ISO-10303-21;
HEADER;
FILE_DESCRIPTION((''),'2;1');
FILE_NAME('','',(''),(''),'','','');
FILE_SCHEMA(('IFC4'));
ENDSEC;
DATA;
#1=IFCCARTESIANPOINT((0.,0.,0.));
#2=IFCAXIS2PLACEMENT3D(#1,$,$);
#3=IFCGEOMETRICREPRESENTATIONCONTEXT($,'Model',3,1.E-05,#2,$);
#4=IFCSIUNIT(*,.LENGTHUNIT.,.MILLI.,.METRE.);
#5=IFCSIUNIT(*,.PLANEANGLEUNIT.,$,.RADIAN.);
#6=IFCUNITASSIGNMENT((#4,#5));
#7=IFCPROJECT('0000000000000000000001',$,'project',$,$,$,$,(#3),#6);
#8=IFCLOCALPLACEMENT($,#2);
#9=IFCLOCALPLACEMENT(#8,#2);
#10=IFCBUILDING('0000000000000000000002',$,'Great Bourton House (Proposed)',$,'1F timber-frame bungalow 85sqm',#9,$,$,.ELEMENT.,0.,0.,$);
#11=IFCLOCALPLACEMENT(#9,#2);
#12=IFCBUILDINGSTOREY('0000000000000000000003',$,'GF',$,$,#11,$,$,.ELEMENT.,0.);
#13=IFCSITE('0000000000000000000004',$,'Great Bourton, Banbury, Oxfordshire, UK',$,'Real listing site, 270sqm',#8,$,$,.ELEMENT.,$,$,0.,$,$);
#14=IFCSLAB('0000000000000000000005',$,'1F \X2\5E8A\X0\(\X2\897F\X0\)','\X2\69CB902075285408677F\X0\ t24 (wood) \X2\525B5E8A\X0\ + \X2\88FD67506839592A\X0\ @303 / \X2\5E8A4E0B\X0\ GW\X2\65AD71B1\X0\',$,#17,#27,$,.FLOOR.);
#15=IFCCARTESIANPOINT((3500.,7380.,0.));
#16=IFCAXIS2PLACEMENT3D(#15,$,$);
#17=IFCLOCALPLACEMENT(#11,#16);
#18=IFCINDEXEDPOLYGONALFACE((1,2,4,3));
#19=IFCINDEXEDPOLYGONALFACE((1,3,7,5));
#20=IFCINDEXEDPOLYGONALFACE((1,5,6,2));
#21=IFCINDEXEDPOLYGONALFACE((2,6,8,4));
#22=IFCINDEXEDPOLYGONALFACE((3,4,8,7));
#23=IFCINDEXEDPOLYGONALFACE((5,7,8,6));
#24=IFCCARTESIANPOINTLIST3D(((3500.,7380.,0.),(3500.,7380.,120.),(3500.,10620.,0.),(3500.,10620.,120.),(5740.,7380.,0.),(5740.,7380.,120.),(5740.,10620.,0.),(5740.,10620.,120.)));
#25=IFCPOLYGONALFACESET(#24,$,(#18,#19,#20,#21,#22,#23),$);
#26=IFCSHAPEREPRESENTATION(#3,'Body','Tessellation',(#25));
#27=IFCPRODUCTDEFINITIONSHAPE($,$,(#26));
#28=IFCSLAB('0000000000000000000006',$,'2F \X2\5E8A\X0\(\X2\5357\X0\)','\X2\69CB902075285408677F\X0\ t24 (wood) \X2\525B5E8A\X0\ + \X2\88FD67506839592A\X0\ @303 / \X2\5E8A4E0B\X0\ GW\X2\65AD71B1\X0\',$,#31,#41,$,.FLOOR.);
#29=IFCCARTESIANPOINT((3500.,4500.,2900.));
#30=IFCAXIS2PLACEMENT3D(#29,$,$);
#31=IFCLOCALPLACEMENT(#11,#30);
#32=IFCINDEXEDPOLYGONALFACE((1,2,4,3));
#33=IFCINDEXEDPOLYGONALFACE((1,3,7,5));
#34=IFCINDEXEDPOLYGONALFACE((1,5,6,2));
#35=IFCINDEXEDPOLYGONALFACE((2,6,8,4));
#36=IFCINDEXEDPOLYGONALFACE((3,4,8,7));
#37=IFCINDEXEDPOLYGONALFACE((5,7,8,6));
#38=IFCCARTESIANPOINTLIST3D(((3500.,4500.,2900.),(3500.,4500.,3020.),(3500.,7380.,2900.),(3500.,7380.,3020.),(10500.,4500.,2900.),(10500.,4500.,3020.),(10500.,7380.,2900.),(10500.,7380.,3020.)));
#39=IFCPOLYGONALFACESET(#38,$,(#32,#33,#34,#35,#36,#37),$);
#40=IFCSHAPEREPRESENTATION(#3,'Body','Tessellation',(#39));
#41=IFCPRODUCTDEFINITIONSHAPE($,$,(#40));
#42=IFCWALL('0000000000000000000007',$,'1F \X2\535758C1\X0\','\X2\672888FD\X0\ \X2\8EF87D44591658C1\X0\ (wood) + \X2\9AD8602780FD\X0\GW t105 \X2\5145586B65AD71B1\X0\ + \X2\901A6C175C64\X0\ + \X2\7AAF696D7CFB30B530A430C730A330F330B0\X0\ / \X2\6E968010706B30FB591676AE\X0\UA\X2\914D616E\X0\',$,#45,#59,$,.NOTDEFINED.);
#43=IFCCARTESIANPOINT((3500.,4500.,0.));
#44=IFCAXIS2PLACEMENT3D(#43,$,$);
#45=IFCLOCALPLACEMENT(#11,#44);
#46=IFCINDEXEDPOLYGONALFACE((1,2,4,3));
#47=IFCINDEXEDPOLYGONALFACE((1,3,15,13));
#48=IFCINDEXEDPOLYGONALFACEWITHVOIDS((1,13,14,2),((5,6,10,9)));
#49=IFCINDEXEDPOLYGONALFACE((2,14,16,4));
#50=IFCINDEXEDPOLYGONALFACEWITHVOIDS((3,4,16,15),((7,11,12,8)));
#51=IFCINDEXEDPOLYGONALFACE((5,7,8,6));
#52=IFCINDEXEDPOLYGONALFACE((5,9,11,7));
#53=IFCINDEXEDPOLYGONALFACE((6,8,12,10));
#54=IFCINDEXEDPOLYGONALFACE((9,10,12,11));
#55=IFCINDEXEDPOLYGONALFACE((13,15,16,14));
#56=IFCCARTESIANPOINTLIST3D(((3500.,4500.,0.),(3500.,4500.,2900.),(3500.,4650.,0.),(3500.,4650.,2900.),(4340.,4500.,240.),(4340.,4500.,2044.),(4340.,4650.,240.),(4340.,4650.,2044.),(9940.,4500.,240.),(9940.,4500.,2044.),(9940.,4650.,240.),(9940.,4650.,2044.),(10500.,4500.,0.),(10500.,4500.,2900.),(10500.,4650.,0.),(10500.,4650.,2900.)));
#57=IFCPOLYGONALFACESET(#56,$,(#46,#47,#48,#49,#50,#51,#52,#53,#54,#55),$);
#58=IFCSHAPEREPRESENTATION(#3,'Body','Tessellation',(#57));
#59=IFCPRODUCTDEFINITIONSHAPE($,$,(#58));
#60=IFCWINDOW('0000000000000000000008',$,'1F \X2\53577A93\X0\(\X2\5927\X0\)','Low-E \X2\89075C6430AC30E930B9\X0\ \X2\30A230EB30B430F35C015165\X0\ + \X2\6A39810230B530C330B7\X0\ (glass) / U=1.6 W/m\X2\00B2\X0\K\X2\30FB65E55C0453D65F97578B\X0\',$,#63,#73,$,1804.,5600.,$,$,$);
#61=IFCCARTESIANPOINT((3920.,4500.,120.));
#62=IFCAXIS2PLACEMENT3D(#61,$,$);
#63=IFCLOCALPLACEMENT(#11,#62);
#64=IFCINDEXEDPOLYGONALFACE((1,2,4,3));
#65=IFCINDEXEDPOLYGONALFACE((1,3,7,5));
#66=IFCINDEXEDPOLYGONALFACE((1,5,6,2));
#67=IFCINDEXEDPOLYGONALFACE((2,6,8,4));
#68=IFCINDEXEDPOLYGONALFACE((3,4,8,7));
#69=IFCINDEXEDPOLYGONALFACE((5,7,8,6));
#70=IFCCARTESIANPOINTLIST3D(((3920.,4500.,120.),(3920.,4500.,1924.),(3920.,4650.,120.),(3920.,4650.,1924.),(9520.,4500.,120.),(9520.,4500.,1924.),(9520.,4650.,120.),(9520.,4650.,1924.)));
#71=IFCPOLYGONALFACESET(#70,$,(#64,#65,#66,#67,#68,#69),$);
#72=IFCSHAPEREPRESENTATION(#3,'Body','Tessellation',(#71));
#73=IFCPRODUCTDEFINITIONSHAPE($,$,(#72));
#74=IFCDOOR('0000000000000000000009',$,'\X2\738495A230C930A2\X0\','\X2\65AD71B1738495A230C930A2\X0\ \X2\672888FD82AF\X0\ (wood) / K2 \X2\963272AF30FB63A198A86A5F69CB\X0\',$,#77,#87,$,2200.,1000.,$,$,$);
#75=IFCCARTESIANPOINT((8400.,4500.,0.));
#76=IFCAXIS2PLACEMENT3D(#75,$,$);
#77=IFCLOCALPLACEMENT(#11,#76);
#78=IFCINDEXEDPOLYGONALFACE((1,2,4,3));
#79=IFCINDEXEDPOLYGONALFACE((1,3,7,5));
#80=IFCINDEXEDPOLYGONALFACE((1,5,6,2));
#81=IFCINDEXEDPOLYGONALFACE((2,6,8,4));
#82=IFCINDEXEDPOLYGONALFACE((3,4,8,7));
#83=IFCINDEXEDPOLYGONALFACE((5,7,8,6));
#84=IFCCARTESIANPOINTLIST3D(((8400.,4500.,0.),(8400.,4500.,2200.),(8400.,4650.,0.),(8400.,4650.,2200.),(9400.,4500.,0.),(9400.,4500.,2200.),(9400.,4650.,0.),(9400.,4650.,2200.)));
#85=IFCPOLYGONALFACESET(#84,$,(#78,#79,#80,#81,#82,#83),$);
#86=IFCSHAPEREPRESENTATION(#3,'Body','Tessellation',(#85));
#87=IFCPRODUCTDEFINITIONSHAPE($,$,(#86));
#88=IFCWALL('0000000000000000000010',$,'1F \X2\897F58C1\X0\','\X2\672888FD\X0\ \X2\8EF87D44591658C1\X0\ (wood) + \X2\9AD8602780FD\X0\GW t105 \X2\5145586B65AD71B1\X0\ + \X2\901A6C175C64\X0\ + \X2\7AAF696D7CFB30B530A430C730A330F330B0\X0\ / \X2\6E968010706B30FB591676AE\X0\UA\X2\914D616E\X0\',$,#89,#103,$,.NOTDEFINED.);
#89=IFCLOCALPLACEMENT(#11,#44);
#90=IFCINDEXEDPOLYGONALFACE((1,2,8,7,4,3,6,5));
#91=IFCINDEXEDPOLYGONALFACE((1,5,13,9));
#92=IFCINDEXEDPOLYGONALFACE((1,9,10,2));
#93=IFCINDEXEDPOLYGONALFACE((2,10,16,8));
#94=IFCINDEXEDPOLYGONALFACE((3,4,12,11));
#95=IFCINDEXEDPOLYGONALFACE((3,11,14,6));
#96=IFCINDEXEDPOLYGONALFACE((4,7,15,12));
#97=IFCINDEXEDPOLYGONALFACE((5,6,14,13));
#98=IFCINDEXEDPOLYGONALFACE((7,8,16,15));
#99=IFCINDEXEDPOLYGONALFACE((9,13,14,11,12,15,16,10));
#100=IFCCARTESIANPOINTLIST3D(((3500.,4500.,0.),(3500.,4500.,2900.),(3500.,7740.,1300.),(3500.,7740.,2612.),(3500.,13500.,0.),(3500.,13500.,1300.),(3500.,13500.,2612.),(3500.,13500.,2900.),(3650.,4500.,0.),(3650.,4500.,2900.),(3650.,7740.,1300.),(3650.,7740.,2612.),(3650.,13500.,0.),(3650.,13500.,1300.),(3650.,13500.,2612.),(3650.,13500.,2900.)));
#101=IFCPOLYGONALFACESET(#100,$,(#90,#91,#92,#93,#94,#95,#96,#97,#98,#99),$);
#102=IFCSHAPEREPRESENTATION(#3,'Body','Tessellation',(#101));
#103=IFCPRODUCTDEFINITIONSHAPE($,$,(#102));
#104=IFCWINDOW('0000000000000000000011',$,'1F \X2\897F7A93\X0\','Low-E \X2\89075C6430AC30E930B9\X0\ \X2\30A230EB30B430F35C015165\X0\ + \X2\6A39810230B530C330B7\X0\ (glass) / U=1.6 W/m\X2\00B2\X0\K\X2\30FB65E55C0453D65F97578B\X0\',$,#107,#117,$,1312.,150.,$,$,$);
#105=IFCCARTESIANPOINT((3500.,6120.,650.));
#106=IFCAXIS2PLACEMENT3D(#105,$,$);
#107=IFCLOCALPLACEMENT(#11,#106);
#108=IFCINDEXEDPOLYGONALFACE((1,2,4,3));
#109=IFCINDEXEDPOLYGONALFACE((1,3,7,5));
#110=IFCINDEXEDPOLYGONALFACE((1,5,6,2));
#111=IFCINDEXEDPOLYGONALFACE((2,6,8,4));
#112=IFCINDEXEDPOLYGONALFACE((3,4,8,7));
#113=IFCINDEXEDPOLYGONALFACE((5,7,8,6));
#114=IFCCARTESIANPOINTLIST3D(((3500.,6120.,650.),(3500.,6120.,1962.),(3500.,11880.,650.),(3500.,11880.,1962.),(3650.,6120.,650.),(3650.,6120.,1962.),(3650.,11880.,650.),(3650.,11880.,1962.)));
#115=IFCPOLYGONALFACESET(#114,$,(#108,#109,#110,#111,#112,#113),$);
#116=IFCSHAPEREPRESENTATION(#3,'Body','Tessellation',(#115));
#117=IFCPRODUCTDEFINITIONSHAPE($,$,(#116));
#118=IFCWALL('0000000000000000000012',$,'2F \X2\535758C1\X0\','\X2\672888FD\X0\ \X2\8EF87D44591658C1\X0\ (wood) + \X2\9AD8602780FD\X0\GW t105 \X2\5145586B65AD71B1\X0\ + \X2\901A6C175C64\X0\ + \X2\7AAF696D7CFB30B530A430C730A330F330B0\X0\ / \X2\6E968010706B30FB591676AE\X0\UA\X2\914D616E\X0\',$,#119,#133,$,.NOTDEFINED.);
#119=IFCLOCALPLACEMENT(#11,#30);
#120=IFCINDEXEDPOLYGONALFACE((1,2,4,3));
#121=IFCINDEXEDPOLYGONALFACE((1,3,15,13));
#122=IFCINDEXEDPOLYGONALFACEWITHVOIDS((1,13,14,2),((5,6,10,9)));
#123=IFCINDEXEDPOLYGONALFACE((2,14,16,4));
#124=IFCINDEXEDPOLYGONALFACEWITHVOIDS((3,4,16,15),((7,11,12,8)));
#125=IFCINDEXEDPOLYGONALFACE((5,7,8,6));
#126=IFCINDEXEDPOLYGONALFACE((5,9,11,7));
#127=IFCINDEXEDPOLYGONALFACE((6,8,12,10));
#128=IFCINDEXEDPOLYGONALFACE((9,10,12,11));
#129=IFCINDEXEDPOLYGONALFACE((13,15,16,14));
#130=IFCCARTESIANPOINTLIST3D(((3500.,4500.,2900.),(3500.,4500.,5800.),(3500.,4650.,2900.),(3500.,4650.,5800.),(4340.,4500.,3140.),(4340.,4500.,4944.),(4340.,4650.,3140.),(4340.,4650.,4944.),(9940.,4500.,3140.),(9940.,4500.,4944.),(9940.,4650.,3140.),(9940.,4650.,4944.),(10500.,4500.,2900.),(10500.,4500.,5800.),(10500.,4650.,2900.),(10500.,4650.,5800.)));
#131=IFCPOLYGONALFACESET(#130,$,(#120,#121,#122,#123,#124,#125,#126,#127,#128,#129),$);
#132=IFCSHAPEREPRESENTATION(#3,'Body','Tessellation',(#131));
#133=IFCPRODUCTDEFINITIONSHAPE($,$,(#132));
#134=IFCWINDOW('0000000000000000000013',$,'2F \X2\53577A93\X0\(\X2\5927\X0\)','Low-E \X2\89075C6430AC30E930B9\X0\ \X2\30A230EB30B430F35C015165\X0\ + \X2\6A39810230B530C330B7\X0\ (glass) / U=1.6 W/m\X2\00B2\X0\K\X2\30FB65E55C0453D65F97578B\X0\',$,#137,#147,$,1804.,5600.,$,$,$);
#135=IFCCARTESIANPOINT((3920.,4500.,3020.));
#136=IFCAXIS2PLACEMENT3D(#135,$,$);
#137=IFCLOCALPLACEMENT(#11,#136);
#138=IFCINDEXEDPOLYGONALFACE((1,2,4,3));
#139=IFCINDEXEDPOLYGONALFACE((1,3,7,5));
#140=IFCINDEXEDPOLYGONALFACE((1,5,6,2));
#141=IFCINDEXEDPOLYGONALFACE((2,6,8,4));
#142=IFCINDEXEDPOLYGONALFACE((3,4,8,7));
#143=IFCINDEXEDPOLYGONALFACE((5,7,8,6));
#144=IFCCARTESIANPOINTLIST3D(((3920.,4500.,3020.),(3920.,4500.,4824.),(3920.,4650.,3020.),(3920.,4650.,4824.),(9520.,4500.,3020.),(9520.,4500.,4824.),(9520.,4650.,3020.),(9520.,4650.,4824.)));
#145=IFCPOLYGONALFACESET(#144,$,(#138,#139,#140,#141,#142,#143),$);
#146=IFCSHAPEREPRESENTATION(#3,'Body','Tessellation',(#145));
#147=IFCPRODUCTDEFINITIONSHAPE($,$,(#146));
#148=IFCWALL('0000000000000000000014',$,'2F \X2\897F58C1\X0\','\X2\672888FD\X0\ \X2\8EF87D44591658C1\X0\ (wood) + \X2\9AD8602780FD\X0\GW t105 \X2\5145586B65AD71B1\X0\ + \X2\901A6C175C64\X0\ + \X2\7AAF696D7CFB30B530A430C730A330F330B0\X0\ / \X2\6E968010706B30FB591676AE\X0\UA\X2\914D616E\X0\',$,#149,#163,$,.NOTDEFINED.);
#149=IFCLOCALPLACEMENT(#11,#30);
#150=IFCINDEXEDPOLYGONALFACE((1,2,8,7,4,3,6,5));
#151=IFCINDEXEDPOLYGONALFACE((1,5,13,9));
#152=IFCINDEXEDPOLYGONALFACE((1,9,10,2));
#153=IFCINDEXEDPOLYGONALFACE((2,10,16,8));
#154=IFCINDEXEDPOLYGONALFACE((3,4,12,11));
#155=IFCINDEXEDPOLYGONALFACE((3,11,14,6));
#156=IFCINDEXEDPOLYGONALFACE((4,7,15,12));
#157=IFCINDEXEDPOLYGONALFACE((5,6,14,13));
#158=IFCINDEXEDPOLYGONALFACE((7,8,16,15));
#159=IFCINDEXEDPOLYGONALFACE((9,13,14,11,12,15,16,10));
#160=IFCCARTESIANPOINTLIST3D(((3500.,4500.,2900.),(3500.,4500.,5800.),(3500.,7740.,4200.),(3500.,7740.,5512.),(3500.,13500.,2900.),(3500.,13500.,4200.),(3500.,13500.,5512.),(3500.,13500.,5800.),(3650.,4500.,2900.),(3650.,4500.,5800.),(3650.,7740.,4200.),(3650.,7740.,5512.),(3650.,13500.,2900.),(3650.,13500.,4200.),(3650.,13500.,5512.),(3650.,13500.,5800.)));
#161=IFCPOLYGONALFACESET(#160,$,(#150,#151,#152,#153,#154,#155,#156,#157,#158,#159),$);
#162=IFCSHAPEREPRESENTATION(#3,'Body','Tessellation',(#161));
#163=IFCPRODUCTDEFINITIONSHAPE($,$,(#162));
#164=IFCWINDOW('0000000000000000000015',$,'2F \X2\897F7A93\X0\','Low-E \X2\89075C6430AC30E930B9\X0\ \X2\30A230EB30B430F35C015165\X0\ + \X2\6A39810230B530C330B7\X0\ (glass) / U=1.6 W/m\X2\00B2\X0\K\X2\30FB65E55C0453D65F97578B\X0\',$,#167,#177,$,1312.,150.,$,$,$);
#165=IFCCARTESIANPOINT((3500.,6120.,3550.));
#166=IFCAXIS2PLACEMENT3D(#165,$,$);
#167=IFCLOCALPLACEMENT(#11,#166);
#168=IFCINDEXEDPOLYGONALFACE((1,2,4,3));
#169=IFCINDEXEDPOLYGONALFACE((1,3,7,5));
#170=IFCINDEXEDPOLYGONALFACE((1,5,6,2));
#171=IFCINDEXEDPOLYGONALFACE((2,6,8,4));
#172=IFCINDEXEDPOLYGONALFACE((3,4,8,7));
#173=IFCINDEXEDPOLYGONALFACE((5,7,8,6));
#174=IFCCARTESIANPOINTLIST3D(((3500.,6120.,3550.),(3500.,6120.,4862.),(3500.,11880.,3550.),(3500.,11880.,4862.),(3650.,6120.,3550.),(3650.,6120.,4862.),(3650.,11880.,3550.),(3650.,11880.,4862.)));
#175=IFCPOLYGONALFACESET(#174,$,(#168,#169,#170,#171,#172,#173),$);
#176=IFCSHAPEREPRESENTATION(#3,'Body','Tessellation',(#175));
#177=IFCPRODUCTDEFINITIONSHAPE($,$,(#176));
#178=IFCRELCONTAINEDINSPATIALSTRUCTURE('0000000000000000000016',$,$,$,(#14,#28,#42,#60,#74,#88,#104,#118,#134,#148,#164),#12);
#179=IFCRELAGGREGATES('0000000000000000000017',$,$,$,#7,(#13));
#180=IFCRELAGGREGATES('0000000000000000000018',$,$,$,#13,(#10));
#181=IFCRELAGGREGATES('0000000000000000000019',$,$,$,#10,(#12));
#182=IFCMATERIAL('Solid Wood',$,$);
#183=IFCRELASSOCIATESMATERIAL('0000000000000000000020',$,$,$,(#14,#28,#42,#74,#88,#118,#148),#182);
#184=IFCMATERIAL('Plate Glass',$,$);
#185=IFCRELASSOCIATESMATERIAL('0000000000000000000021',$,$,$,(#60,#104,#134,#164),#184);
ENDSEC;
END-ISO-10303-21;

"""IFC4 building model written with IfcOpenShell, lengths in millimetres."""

from ifc_helpers import new_model, si_unit, frame, frame_2d, origin, place, context, project, spatial, rectangle, extrude, material, element, fill, save


model = new_model("IFC4")

# Units and contexts
model_context = context("Model", 3, precision=1e-05, world=origin())
ifc_project = project(units=[si_unit("LENGTHUNIT", "METRE", prefix="MILLI"), si_unit("PLANEANGLEUNIT", "RADIAN")], contexts=[model_context])

# Site, building, storey
site_placement = place(None, origin())
site = spatial("IfcSite", under=ifc_project, at=site_placement, Name="Great Bourton, Banbury, Oxfordshire, UK", ObjectType="Real listing site, 270sqm", CompositionType="ELEMENT", RefElevation=0.0)
building_placement = place(site_placement, origin())
building = spatial("IfcBuilding", under=site, at=building_placement, Name="Great Bourton House (Proposed)", ObjectType="1F timber-frame bungalow 85sqm", CompositionType="ELEMENT", ElevationOfRefHeight=0.0, ElevationOfTerrain=0.0)
storey_placement = place(building_placement, origin())
storey = spatial("IfcBuildingStorey", under=building, at=storey_placement, Name="GF", CompositionType="ELEMENT", Elevation=0.0)

# Slabs
ifc_material_1 = material(Name="Solid Wood")
slab_1_placement = place(storey_placement, frame((3500.0, 7380.0, 0.0)))
element("IfcSlab", 1, at=slab_1_placement, inside=storey, material=ifc_material_1, Name="1F 床(西)", Description="構造用合板 t24 (wood) 剛床 + 製材根太 @303 / 床下 GW断熱", PredefinedType="FLOOR", context=model_context, shape_type="SweptSolid", body=[
    extrude(rectangle(XDim=2240.0, YDim=3240.0, at=frame_2d((1120.0, 1620.0))), frame((3500.0, 7380.0, 0.0)), (0.0, 0.0, 1.0), 120.0),
])
slab_2_placement = place(storey_placement, frame((3500.0, 4500.0, 2900.0)))
element("IfcSlab", 2, at=slab_2_placement, inside=storey, material=ifc_material_1, Name="2F 床(南)", Description="構造用合板 t24 (wood) 剛床 + 製材根太 @303 / 床下 GW断熱", PredefinedType="FLOOR", context=model_context, shape_type="SweptSolid", body=[
    extrude(rectangle(XDim=7000.0, YDim=2880.0, at=frame_2d((3500.0, 1440.0))), frame((3500.0, 4500.0, 2900.0)), (0.0, 0.0, 1.0), 120.0),
])

# Wall, openings, window, door
wall_1_placement = place(storey_placement, frame((3500.0, 4500.0, 0.0)))
wall_1 = element("IfcWall", 3, at=wall_1_placement, inside=storey, material=ifc_material_1, Name="1F 南壁", Description="木製 軸組外壁 (wood) + 高性能GW t105 充填断熱 + 通気層 + 窯業系サイディング / 準耐火・外皮UA配慮", PredefinedType="NOTDEFINED", context=model_context, shape_type="SweptSolid", body=[
    extrude(rectangle(XDim=7000.0, YDim=150.0, at=frame_2d((3500.0, 75.0))), frame((3500.0, 4500.0, 0.0)), (0.0, 0.0, 1.0), 2900.0),
])
opening_1_placement = place(storey_placement, frame((3920.0, 4500.0, 120.0)))
opening_1 = element("IfcOpeningElement", 4, at=opening_1_placement, cuts=wall_1, PredefinedType="NOTDEFINED", context=model_context, shape_type="SweptSolid", body=[
    extrude(rectangle(XDim=5600.0, YDim=150.0, at=frame_2d((2800.0, 75.0))), frame((3920.0, 4500.0, 120.0)), (0.0, 0.0, 1.0), 1804.0),
])
opening_2_placement = place(storey_placement, frame((8400.0, 4500.0, 0.0)))
opening_2 = element("IfcOpeningElement", 5, at=opening_2_placement, cuts=wall_1, PredefinedType="NOTDEFINED", context=model_context, shape_type="SweptSolid", body=[
    extrude(rectangle(XDim=1000.0, YDim=150.0, at=frame_2d((500.0, 75.0))), frame((8400.0, 4500.0, 0.0)), (0.0, 0.0, 1.0), 2200.0),
])
ifc_material_2 = material(Name="Plate Glass")
window_1_placement = place(storey_placement, frame((3920.0, 4500.0, 120.0)))
window_1 = element("IfcWindow", 6, at=window_1_placement, inside=storey, material=ifc_material_2, Name="1F 南窓(大)", Description="Low-E 複層ガラス アルゴン封入 + 樹脂サッシ (glass) / U=1.6 W/m²K・日射取得型", OverallHeight=1804.0, OverallWidth=5600.0, context=model_context, shape_type="SweptSolid", body=[
    extrude(rectangle(XDim=5600.0, YDim=150.0, at=frame_2d((2800.0, 75.0))), frame((3920.0, 4500.0, 120.0)), (0.0, 0.0, 1.0), 1804.0),
])
fill(opening_1, window_1)
door_placement = place(storey_placement, frame((8400.0, 4500.0, 0.0)))
door = element("IfcDoor", 7, at=door_placement, inside=storey, material=ifc_material_1, Name="玄関ドア", Description="断熱玄関ドア 木製芯 (wood) / K2 防犯・採風機構", OverallHeight=2200.0, OverallWidth=1000.0, context=model_context, shape_type="SweptSolid", body=[
    extrude(rectangle(XDim=1000.0, YDim=150.0, at=frame_2d((500.0, 75.0))), frame((8400.0, 4500.0, 0.0)), (0.0, 0.0, 1.0), 2200.0),
])
fill(opening_2, door)

# Walls, openings, windows
wall_2_placement = place(storey_placement, frame((3500.0, 4500.0, 0.0)))
wall_2 = element("IfcWall", 8, at=wall_2_placement, inside=storey, material=ifc_material_1, Name="1F 西壁", Description="木製 軸組外壁 (wood) + 高性能GW t105 充填断熱 + 通気層 + 窯業系サイディング / 準耐火・外皮UA配慮", PredefinedType="NOTDEFINED", context=model_context, shape_type="SweptSolid", body=[
    extrude(rectangle(XDim=150.0, YDim=9000.0, at=frame_2d((75.0, 4500.0))), frame((3500.0, 4500.0, 0.0)), (0.0, 0.0, 1.0), 2900.0),
])
opening_3_placement = place(storey_placement, frame((3500.0, 6120.0, 650.0)))
opening_3 = element("IfcOpeningElement", 9, at=opening_3_placement, cuts=wall_2, PredefinedType="NOTDEFINED", context=model_context, shape_type="SweptSolid", body=[
    extrude(rectangle(XDim=150.0, YDim=5760.0, at=frame_2d((75.0, 2880.0))), frame((3500.0, 6120.0, 650.0)), (0.0, 0.0, 1.0), 1312.0),
])
window_2_placement = place(storey_placement, frame((3500.0, 6120.0, 650.0)))
window_2 = element("IfcWindow", 10, at=window_2_placement, inside=storey, material=ifc_material_2, Name="1F 西窓", Description="Low-E 複層ガラス アルゴン封入 + 樹脂サッシ (glass) / U=1.6 W/m²K・日射取得型", OverallHeight=1312.0, OverallWidth=150.0, context=model_context, shape_type="SweptSolid", body=[
    extrude(rectangle(XDim=150.0, YDim=5760.0, at=frame_2d((75.0, 2880.0))), frame((3500.0, 6120.0, 650.0)), (0.0, 0.0, 1.0), 1312.0),
])
fill(opening_3, window_2)
wall_3_placement = place(storey_placement, frame((3500.0, 4500.0, 2900.0)))
wall_3 = element("IfcWall", 11, at=wall_3_placement, inside=storey, material=ifc_material_1, Name="2F 南壁", Description="木製 軸組外壁 (wood) + 高性能GW t105 充填断熱 + 通気層 + 窯業系サイディング / 準耐火・外皮UA配慮", PredefinedType="NOTDEFINED", context=model_context, shape_type="SweptSolid", body=[
    extrude(rectangle(XDim=7000.0, YDim=150.0, at=frame_2d((3500.0, 75.0))), frame((3500.0, 4500.0, 2900.0)), (0.0, 0.0, 1.0), 2900.0),
])
opening_4_placement = place(storey_placement, frame((3920.0, 4500.0, 3020.0)))
opening_4 = element("IfcOpeningElement", 12, at=opening_4_placement, cuts=wall_3, PredefinedType="NOTDEFINED", context=model_context, shape_type="SweptSolid", body=[
    extrude(rectangle(XDim=5600.0, YDim=150.0, at=frame_2d((2800.0, 75.0))), frame((3920.0, 4500.0, 3020.0)), (0.0, 0.0, 1.0), 1804.0),
])
window_3_placement = place(storey_placement, frame((3920.0, 4500.0, 3020.0)))
window_3 = element("IfcWindow", 13, at=window_3_placement, inside=storey, material=ifc_material_2, Name="2F 南窓(大)", Description="Low-E 複層ガラス アルゴン封入 + 樹脂サッシ (glass) / U=1.6 W/m²K・日射取得型", OverallHeight=1804.0, OverallWidth=5600.0, context=model_context, shape_type="SweptSolid", body=[
    extrude(rectangle(XDim=5600.0, YDim=150.0, at=frame_2d((2800.0, 75.0))), frame((3920.0, 4500.0, 3020.0)), (0.0, 0.0, 1.0), 1804.0),
])
fill(opening_4, window_3)
wall_4_placement = place(storey_placement, frame((3500.0, 4500.0, 2900.0)))
wall_4 = element("IfcWall", 14, at=wall_4_placement, inside=storey, material=ifc_material_1, Name="2F 西壁", Description="木製 軸組外壁 (wood) + 高性能GW t105 充填断熱 + 通気層 + 窯業系サイディング / 準耐火・外皮UA配慮", PredefinedType="NOTDEFINED", context=model_context, shape_type="SweptSolid", body=[
    extrude(rectangle(XDim=150.0, YDim=9000.0, at=frame_2d((75.0, 4500.0))), frame((3500.0, 4500.0, 2900.0)), (0.0, 0.0, 1.0), 2900.0),
])
opening_5_placement = place(storey_placement, frame((3500.0, 6120.0, 3550.0)))
opening_5 = element("IfcOpeningElement", 15, at=opening_5_placement, cuts=wall_4, PredefinedType="NOTDEFINED", context=model_context, shape_type="SweptSolid", body=[
    extrude(rectangle(XDim=150.0, YDim=5760.0, at=frame_2d((75.0, 2880.0))), frame((3500.0, 6120.0, 3550.0)), (0.0, 0.0, 1.0), 1312.0),
])
window_4_placement = place(storey_placement, frame((3500.0, 6120.0, 3550.0)))
window_4 = element("IfcWindow", 16, at=window_4_placement, inside=storey, material=ifc_material_2, Name="2F 西窓", Description="Low-E 複層ガラス アルゴン封入 + 樹脂サッシ (glass) / U=1.6 W/m²K・日射取得型", OverallHeight=1312.0, OverallWidth=150.0, context=model_context, shape_type="SweptSolid", body=[
    extrude(rectangle(XDim=150.0, YDim=5760.0, at=frame_2d((75.0, 2880.0))), frame((3500.0, 6120.0, 3550.0)), (0.0, 0.0, 1.0), 1312.0),
])
fill(opening_5, window_4)

save(model, "model.ifc")
